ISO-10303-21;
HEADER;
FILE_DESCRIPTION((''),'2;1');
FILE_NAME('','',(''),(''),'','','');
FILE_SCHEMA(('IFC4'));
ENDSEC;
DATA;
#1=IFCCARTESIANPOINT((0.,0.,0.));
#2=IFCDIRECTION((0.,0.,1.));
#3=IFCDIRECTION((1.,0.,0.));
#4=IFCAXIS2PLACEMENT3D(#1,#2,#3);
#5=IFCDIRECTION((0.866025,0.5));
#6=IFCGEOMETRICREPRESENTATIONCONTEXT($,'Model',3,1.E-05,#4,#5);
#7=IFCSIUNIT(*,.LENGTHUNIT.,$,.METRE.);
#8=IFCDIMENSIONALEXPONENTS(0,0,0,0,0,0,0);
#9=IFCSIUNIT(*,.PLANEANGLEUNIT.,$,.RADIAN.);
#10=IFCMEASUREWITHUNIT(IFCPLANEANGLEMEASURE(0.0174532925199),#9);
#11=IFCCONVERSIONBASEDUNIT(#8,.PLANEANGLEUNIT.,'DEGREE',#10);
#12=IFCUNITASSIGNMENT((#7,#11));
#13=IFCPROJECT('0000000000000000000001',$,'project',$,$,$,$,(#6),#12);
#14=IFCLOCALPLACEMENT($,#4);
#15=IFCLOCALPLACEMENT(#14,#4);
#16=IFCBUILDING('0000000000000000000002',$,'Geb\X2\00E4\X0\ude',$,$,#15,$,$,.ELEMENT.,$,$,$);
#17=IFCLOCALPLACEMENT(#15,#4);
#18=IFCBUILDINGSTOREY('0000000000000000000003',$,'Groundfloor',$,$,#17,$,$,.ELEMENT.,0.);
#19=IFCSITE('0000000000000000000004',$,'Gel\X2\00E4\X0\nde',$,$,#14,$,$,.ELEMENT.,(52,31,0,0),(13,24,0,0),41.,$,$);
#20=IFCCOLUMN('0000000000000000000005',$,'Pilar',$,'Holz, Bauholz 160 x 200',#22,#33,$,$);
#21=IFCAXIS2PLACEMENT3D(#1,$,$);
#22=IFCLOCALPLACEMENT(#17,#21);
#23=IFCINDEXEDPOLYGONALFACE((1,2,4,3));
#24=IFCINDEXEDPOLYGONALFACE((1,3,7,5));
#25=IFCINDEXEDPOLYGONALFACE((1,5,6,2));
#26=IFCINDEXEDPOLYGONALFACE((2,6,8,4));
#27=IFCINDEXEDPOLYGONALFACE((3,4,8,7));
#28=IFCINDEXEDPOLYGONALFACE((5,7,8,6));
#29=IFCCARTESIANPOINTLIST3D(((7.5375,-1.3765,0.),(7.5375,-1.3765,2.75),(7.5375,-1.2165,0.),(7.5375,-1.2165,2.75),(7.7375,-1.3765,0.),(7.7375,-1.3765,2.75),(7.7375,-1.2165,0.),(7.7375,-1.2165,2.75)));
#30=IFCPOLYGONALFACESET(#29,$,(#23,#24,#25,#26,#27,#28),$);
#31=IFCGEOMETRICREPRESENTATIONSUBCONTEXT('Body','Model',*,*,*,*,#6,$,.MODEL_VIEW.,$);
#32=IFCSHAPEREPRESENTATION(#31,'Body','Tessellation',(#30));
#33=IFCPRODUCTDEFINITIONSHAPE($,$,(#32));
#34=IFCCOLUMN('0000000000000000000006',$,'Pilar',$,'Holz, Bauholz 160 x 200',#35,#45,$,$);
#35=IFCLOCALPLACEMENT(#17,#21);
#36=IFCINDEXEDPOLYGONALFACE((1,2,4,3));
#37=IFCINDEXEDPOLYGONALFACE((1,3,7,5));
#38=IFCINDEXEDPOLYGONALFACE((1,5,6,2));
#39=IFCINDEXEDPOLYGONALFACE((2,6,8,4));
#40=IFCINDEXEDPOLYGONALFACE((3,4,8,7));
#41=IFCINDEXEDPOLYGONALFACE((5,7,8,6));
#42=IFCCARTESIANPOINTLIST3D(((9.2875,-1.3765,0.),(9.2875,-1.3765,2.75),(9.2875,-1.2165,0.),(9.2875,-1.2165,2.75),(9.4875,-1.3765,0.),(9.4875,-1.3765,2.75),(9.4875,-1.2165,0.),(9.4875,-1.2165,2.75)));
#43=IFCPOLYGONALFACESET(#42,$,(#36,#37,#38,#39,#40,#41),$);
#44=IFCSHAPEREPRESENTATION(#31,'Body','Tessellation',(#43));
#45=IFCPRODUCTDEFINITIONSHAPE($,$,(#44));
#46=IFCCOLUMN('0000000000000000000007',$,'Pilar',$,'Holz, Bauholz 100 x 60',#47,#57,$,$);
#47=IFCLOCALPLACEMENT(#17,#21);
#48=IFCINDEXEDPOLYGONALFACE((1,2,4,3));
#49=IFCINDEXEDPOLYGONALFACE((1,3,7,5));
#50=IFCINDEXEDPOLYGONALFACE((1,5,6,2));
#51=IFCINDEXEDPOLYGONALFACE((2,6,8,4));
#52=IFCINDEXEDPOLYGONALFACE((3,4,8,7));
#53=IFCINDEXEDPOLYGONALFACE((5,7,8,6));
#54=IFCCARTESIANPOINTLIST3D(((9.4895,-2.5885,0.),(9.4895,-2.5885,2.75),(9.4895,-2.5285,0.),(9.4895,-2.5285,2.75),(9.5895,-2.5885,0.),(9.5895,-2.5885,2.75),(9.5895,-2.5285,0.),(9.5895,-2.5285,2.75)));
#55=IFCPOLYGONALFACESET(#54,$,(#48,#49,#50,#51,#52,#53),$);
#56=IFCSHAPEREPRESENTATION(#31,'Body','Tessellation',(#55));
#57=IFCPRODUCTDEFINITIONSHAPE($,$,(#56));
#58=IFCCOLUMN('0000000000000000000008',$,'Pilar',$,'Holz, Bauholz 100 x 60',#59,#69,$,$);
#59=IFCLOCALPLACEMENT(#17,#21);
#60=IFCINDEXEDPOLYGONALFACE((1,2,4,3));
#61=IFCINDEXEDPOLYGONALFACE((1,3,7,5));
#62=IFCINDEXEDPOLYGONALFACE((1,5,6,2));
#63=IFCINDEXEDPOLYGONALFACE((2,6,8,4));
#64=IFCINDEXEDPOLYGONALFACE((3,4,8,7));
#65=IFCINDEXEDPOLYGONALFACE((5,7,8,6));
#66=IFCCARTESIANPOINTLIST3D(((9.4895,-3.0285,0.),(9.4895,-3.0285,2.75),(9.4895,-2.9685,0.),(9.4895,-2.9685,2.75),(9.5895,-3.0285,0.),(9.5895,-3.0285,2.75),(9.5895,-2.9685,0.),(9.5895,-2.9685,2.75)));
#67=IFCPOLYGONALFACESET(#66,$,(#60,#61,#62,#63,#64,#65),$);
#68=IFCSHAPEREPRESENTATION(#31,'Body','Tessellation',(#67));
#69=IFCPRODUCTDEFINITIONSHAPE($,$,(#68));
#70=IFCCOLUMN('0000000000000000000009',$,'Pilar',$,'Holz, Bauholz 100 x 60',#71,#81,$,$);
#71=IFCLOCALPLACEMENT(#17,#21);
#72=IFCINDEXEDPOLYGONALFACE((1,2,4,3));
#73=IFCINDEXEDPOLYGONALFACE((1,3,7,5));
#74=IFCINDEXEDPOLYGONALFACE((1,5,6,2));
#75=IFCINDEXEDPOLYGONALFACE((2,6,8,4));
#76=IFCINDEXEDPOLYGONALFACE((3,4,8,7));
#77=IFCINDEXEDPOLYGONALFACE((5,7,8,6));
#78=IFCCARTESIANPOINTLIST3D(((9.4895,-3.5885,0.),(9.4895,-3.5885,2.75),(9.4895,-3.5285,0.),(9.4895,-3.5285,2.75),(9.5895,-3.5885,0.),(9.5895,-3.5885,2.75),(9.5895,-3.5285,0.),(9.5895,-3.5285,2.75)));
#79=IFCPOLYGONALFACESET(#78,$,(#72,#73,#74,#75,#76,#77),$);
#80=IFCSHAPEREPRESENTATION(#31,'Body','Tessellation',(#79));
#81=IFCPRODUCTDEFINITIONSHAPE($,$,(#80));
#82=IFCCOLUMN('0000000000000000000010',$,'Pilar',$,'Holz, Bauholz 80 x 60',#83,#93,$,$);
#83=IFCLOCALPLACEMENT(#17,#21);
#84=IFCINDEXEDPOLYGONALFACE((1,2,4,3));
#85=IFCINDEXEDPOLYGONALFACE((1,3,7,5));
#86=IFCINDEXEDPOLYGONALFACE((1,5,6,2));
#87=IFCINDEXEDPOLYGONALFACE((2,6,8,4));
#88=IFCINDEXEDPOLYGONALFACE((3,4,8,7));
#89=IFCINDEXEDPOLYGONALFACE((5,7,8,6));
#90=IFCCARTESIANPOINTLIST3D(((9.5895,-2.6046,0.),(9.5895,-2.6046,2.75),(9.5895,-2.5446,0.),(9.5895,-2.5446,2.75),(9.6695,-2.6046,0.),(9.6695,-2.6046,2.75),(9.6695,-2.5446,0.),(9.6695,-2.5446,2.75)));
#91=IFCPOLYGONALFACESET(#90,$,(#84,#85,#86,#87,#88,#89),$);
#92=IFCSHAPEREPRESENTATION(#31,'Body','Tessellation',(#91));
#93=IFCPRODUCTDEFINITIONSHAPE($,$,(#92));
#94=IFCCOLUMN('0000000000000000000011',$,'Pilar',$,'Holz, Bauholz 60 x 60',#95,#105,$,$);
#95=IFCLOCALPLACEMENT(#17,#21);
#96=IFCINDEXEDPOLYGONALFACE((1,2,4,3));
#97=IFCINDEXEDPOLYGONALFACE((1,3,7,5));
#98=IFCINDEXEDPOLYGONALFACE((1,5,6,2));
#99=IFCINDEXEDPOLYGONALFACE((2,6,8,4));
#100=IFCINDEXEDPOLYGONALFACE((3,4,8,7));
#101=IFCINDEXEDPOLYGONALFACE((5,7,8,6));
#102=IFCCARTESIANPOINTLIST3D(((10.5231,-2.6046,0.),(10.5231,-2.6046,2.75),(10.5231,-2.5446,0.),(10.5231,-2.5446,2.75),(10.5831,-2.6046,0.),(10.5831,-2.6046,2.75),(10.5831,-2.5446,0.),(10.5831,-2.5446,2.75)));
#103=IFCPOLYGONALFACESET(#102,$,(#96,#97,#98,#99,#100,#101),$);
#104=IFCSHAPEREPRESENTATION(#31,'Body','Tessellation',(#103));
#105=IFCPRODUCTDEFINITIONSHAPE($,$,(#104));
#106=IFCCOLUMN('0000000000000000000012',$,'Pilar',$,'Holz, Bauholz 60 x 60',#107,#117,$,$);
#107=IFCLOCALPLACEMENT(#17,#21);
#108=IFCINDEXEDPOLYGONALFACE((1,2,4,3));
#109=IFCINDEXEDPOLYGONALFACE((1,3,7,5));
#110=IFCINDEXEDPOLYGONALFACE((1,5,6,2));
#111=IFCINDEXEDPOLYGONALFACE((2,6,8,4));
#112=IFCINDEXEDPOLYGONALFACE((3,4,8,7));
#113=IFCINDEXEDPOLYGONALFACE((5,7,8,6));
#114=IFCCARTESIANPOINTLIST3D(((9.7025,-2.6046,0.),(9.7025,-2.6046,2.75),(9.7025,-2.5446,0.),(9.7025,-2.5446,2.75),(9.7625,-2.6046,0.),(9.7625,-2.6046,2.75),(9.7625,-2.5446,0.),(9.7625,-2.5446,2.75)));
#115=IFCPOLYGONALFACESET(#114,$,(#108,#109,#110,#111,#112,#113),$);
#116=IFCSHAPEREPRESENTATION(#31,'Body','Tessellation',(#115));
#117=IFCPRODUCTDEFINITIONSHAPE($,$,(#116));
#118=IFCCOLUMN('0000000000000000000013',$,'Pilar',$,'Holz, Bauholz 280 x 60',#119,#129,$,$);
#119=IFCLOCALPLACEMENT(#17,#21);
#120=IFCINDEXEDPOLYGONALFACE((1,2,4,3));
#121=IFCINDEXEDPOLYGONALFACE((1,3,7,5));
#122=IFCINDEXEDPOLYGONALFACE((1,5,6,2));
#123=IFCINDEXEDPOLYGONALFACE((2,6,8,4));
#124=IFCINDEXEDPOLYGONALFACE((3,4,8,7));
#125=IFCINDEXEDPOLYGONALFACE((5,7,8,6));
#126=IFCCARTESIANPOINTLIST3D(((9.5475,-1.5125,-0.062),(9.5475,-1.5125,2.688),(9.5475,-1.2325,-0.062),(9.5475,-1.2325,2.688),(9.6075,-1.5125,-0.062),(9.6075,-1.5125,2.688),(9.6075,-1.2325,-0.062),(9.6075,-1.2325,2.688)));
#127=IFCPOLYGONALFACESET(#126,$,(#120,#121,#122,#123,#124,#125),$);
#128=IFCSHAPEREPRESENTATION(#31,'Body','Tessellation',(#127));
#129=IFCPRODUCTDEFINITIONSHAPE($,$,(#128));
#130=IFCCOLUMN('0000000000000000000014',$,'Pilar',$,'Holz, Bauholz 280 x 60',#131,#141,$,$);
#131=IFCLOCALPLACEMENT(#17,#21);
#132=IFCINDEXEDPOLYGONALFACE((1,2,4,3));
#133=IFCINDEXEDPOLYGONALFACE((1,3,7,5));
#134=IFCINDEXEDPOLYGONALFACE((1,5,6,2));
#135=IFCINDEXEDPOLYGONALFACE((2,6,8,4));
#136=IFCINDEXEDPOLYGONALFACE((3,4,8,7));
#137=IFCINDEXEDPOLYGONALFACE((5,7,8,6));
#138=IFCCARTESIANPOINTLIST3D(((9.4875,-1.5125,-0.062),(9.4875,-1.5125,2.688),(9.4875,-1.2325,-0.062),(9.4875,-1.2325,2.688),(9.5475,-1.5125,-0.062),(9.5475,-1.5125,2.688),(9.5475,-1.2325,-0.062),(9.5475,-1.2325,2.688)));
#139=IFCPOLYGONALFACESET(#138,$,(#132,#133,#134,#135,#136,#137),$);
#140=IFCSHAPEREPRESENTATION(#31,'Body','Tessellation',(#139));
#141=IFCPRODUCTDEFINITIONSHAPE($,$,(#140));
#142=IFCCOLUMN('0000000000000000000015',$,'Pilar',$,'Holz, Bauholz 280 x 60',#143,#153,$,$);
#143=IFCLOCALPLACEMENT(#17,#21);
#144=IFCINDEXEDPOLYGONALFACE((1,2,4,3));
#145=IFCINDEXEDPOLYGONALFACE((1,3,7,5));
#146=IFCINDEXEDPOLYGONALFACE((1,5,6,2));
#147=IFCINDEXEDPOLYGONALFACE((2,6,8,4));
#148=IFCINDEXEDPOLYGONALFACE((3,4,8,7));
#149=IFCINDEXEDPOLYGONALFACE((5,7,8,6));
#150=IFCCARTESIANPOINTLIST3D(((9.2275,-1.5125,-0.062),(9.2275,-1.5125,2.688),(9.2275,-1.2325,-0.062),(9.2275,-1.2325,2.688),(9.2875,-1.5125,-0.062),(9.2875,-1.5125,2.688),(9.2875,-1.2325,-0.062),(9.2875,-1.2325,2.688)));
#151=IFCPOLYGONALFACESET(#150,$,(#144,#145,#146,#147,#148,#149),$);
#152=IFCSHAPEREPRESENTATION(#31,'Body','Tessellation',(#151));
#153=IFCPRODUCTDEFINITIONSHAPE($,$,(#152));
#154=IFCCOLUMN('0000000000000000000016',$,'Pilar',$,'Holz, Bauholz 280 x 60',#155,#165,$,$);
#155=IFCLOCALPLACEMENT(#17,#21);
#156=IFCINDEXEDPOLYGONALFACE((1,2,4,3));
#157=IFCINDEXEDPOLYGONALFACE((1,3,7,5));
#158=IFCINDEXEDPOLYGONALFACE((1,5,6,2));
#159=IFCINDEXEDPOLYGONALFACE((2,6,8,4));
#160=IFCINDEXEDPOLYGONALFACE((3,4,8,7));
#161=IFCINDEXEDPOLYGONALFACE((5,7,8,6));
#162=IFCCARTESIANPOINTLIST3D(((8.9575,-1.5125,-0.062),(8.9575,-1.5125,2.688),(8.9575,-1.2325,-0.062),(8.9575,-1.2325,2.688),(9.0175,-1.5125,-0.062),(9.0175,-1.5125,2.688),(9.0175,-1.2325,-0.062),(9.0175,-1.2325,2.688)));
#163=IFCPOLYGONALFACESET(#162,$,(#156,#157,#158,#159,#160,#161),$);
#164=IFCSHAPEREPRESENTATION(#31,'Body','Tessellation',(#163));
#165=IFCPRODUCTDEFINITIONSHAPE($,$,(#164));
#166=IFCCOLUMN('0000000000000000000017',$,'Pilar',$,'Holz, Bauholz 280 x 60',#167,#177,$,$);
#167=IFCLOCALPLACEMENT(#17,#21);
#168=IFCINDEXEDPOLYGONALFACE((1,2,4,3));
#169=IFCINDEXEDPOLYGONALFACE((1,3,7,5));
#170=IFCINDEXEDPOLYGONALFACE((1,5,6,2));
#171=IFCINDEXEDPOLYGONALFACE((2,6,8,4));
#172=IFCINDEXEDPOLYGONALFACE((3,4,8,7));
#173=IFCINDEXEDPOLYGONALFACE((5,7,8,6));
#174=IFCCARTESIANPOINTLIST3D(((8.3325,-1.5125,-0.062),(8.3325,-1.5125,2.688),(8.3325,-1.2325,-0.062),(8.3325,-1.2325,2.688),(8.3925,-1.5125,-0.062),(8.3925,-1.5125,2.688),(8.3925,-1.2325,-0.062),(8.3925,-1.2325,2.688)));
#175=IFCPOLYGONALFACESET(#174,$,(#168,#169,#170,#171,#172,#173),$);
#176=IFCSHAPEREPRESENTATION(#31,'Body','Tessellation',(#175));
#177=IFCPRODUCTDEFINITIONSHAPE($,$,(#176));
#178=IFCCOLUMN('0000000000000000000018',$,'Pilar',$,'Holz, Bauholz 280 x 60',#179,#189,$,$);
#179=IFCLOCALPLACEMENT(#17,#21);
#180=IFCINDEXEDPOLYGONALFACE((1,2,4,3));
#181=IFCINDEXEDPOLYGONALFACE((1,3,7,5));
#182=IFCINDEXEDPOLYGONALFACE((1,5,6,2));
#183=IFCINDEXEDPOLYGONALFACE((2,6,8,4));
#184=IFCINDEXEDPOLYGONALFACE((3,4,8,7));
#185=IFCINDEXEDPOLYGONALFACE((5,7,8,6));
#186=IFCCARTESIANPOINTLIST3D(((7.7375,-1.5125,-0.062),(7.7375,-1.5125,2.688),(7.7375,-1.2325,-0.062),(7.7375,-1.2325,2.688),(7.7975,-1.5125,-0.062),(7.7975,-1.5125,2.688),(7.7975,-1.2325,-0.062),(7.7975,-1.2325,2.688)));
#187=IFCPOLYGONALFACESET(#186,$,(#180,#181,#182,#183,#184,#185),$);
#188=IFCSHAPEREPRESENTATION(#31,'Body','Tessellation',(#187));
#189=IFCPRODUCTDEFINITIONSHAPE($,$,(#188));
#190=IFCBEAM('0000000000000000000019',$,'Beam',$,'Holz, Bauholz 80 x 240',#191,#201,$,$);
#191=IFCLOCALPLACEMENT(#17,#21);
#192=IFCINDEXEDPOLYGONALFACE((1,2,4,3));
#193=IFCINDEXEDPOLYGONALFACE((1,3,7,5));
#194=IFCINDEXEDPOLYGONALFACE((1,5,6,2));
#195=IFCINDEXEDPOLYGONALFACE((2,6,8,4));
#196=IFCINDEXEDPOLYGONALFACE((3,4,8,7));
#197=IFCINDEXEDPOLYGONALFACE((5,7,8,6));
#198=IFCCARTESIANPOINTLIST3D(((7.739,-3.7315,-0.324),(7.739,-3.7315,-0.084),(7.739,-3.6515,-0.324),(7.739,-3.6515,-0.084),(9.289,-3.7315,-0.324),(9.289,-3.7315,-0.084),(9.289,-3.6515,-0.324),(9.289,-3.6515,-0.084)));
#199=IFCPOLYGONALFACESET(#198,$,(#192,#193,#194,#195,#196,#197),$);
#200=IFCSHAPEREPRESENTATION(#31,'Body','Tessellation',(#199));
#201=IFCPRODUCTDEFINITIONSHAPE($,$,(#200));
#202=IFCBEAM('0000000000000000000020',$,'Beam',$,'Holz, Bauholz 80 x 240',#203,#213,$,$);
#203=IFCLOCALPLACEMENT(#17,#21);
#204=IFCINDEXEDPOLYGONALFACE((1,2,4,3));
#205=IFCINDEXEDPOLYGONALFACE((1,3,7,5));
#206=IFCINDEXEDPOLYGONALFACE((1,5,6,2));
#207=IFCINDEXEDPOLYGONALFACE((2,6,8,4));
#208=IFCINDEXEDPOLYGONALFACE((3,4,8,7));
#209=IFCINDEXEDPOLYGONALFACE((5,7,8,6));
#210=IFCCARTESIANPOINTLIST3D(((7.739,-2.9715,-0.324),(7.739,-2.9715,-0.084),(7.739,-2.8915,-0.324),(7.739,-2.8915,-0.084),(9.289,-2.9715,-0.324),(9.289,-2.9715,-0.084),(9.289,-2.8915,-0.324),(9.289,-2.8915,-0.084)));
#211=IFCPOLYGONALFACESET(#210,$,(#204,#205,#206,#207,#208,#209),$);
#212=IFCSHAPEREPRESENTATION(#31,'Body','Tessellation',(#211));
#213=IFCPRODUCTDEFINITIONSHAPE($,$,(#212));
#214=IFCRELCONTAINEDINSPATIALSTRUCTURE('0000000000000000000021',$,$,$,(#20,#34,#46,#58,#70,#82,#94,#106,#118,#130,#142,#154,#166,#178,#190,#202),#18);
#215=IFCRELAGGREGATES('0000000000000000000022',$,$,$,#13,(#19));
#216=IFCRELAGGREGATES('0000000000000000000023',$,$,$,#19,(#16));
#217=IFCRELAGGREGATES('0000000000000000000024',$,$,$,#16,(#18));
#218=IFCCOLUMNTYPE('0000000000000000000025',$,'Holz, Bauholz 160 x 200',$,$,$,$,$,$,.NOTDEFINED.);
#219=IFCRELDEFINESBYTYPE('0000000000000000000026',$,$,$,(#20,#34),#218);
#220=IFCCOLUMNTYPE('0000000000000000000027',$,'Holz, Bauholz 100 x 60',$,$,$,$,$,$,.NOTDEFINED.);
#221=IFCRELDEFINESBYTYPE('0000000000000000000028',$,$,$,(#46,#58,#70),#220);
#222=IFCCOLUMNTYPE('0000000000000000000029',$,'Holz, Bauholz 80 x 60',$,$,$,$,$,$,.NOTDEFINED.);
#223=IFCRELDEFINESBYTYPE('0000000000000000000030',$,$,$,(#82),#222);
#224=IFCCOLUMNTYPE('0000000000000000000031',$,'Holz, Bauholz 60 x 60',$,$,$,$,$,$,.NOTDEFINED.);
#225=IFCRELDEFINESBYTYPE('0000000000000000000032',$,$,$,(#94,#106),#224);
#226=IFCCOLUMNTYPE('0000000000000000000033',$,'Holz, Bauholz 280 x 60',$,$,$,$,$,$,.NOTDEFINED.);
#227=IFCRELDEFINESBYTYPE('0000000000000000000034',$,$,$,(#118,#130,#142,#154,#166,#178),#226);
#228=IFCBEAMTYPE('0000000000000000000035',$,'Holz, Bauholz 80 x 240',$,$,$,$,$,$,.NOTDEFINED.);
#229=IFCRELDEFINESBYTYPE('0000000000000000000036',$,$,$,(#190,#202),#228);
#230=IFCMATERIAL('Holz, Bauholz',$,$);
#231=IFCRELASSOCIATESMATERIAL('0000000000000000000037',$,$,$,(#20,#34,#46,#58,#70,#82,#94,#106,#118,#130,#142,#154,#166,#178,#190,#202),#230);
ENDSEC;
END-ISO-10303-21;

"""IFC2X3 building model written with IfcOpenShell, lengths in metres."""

from ifc_helpers import new_model, entity, si_unit, converted_unit, direction, frame, frame_2d, origin_with_axes, origin_2d_with_axis, place, context, subcontext, project, spatial, rectangle, extrude, clip, halfspace, material, type_object, element, save


model = new_model("IFC2X3")

# Units and contexts
model_context = context("Model", 3, precision=1e-05, world=origin_with_axes(), true_north=direction((0.866025, 0.5)))
body_context = subcontext(model_context, "Body", "Model", "MODEL_VIEW")
ifc_project = project(units=[si_unit("LENGTHUNIT", "METRE"), converted_unit("PLANEANGLEUNIT", "DEGREE", entity("IfcPlaneAngleMeasure", 0.0174532925199), si_unit("PLANEANGLEUNIT", "RADIAN"), dimensions=[0, 0, 0, 0, 0, 0, 0])], contexts=[model_context])

# Site, building, storey
site_placement = place(None, origin_with_axes())
site = spatial("IfcSite", under=ifc_project, at=site_placement, Name="Gelände", CompositionType="ELEMENT", RefLatitude=(52, 31, 0, 0), RefLongitude=(13, 24, 0, 0), RefElevation=41.0)
building_placement = place(site_placement, origin_with_axes())
building = spatial("IfcBuilding", under=site, at=building_placement, Name="Gebäude", CompositionType="ELEMENT")
storey_placement = place(building_placement, origin_with_axes())
storey = spatial("IfcBuildingStorey", under=building, at=storey_placement, Name="Groundfloor", CompositionType="ELEMENT", Elevation=0.0)

# Columns
ifc_material_1 = material(Name="Holz, Bauholz")
column_type_1 = type_object("IfcColumnType", Name="Holz, Bauholz 160 x 200", PredefinedType="NOTDEFINED")
for number, where, z_axis, x_axis, name in (
    (1, (7.6375, -1.2965, 0.0), (0.0, 0.0, 1.0), (1.0, 0.0, 0.0), "Pilar"),
    (2, (9.3875, -1.2965, 0.0), (0.0, 0.0, 1.0), (1.0, 0.0, 0.0), "Pilar"),
):
    element("IfcColumn", number, at=place(storey_placement, frame(where, z_axis=z_axis, x_axis=x_axis)), inside=storey, type_object=column_type_1, material=ifc_material_1, Name=name, ObjectType="Holz, Bauholz 160 x 200", context=body_context, shape_type="Clipping", body=[
        clip(clip(extrude(rectangle(XDim=0.16, YDim=0.2, at=origin_2d_with_axis()), frame((0.0, 0.0, 0.0), z_axis=(0.0, 0.0, 1.0), x_axis=(0.0, 1.0, 0.0)), (0.0, 0.0, 1.0), 2.75), halfspace(frame((0.0, 0.0, 2.75), z_axis=(0.0, 0.0, -1.0), x_axis=(0.0, 1.0, 0.0)), True)), halfspace(frame((0.0, 0.0, 0.0), z_axis=(0.0, 0.0, 1.0), x_axis=(0.0, -1.0, 0.0)), True)),
    ])
column_type_2 = type_object("IfcColumnType", Name="Holz, Bauholz 100 x 60", PredefinedType="NOTDEFINED")
for number, where, z_axis, x_axis, name in (
    (3, (9.5395, -2.5585, 0.0), (0.0, 0.0, 1.0), (0.0, -1.0, 0.0), "Pilar"),
    (4, (9.5395, -2.9985, 0.0), (0.0, 0.0, 1.0), (0.0, -1.0, 0.0), "Pilar"),
    (5, (9.5395, -3.5585, 0.0), (0.0, 0.0, 1.0), (0.0, -1.0, 0.0), "Pilar"),
):
    element("IfcColumn", number, at=place(storey_placement, frame(where, z_axis=z_axis, x_axis=x_axis)), inside=storey, type_object=column_type_2, material=ifc_material_1, Name=name, ObjectType="Holz, Bauholz 100 x 60", context=body_context, shape_type="Clipping", body=[
        clip(clip(extrude(rectangle(XDim=0.1, YDim=0.06, at=origin_2d_with_axis()), frame((0.0, 0.0, 0.0), z_axis=(0.0, 0.0, 1.0), x_axis=(0.0, 1.0, 0.0)), (0.0, 0.0, 1.0), 2.75), halfspace(frame((0.0, 0.0, 2.75), z_axis=(0.0, 0.0, -1.0), x_axis=(0.0, 1.0, 0.0)), True)), halfspace(frame((0.0, 0.0, 0.0), z_axis=(0.0, 0.0, 1.0), x_axis=(0.0, -1.0, 0.0)), True)),
    ])
column_type_3 = type_object("IfcColumnType", Name="Holz, Bauholz 80 x 60", PredefinedType="NOTDEFINED")
column_placement = place(storey_placement, frame((9.6295, -2.5746, 0.0), z_axis=(0.0, 0.0, 1.0), x_axis=(0.0, -1.0, 0.0)))
element("IfcColumn", 6, at=column_placement, inside=storey, type_object=column_type_3, material=ifc_material_1, Name="Pilar", ObjectType="Holz, Bauholz 80 x 60", context=body_context, shape_type="Clipping", body=[
    clip(clip(extrude(rectangle(XDim=0.08, YDim=0.06, at=origin_2d_with_axis()), frame((0.0, 0.0, 0.0), z_axis=(0.0, 0.0, 1.0), x_axis=(0.0, 1.0, 0.0)), (0.0, 0.0, 1.0), 2.75), halfspace(frame((0.0, 0.0, 2.75), z_axis=(0.0, 0.0, -1.0), x_axis=(0.0, 1.0, 0.0)), True)), halfspace(frame((0.0, 0.0, 0.0), z_axis=(0.0, 0.0, 1.0), x_axis=(0.0, -1.0, 0.0)), True)),
])
column_type_4 = type_object("IfcColumnType", Name="Holz, Bauholz 60 x 60", PredefinedType="NOTDEFINED")
for number, where, z_axis, x_axis, name in (
    (7, (10.5531, -2.5746, 0.0), (0.0, 0.0, 1.0), (0.0, -1.0, 0.0), "Pilar"),
    (8, (9.7325, -2.5746, 0.0), (0.0, 0.0, 1.0), (0.0, -1.0, 0.0), "Pilar"),
):
    element("IfcColumn", number, at=place(storey_placement, frame(where, z_axis=z_axis, x_axis=x_axis)), inside=storey, type_object=column_type_4, material=ifc_material_1, Name=name, ObjectType="Holz, Bauholz 60 x 60", context=body_context, shape_type="Clipping", body=[
        clip(clip(extrude(rectangle(XDim=0.06, YDim=0.06, at=origin_2d_with_axis()), frame((0.0, 0.0, 0.0), z_axis=(0.0, 0.0, 1.0), x_axis=(0.0, 1.0, 0.0)), (0.0, 0.0, 1.0), 2.75), halfspace(frame((0.0, 0.0, 2.75), z_axis=(0.0, 0.0, -1.0), x_axis=(0.0, 1.0, 0.0)), True)), halfspace(frame((0.0, 0.0, 0.0), z_axis=(0.0, 0.0, 1.0), x_axis=(0.0, -1.0, 0.0)), True)),
    ])
column_type_5 = type_object("IfcColumnType", Name="Holz, Bauholz 280 x 60", PredefinedType="NOTDEFINED")
for number, where, z_axis, x_axis, name in (
    (9, (9.5775, -1.3725, -0.062), (0.0, 0.0, 1.0), (-1.0, 0.0, 0.0), "Pilar"),
    (10, (9.5175, -1.3725, -0.062), (0.0, 0.0, 1.0), (-1.0, 0.0, 0.0), "Pilar"),
    (11, (9.2575, -1.3725, -0.062), (0.0, 0.0, 1.0), (-1.0, 0.0, 0.0), "Pilar"),
    (12, (8.9875, -1.3725, -0.062), (0.0, 0.0, 1.0), (-1.0, 0.0, 0.0), "Pilar"),
    (13, (8.3625, -1.3725, -0.062), (0.0, 0.0, 1.0), (-1.0, 0.0, 0.0), "Pilar"),
    (14, (7.7675, -1.3725, -0.062), (0.0, 0.0, 1.0), (-1.0, 0.0, 0.0), "Pilar"),
):
    element("IfcColumn", number, at=place(storey_placement, frame(where, z_axis=z_axis, x_axis=x_axis)), inside=storey, type_object=column_type_5, material=ifc_material_1, Name=name, ObjectType="Holz, Bauholz 280 x 60", context=body_context, shape_type="Clipping", body=[
        clip(clip(extrude(rectangle(XDim=0.28, YDim=0.06, at=origin_2d_with_axis()), frame((0.0, 0.0, 0.0), z_axis=(0.0, 0.0, 1.0), x_axis=(0.0, 1.0, 0.0)), (0.0, 0.0, 1.0), 2.75), halfspace(frame((0.0, 0.0, 2.75), z_axis=(0.0, 0.0, -1.0), x_axis=(0.0, 1.0, 0.0)), True)), halfspace(frame((0.0, 0.0, 0.0), z_axis=(0.0, 0.0, 1.0), x_axis=(0.0, -1.0, 0.0)), True)),
    ])

# Beams
beam_type = type_object("IfcBeamType", Name="Holz, Bauholz 80 x 240", PredefinedType="NOTDEFINED")
for number, where, z_axis, x_axis, name in (
    (15, (9.289, -3.6915, -0.084), (0.0, 0.0, 1.0), (0.0, 1.0, 0.0), "Beam"),
    (16, (9.289, -2.9315, -0.084), (0.0, 0.0, 1.0), (0.0, 1.0, 0.0), "Beam"),
):
    element("IfcBeam", number, at=place(storey_placement, frame(where, z_axis=z_axis, x_axis=x_axis)), inside=storey, type_object=beam_type, material=ifc_material_1, Name=name, ObjectType="Holz, Bauholz 80 x 240", context=body_context, shape_type="SweptSolid", body=[
        extrude(rectangle(XDim=0.24, YDim=0.08, at=frame_2d((-0.12, 0.0), x_axis=(1.0, 0.0))), frame((0.0, 0.0, 0.0), z_axis=(0.0, 1.0, 0.0), x_axis=(0.0, 0.0, 1.0)), (0.0, 0.0, 1.0), 1.55),
    ])

save(model, "model.ifc")
